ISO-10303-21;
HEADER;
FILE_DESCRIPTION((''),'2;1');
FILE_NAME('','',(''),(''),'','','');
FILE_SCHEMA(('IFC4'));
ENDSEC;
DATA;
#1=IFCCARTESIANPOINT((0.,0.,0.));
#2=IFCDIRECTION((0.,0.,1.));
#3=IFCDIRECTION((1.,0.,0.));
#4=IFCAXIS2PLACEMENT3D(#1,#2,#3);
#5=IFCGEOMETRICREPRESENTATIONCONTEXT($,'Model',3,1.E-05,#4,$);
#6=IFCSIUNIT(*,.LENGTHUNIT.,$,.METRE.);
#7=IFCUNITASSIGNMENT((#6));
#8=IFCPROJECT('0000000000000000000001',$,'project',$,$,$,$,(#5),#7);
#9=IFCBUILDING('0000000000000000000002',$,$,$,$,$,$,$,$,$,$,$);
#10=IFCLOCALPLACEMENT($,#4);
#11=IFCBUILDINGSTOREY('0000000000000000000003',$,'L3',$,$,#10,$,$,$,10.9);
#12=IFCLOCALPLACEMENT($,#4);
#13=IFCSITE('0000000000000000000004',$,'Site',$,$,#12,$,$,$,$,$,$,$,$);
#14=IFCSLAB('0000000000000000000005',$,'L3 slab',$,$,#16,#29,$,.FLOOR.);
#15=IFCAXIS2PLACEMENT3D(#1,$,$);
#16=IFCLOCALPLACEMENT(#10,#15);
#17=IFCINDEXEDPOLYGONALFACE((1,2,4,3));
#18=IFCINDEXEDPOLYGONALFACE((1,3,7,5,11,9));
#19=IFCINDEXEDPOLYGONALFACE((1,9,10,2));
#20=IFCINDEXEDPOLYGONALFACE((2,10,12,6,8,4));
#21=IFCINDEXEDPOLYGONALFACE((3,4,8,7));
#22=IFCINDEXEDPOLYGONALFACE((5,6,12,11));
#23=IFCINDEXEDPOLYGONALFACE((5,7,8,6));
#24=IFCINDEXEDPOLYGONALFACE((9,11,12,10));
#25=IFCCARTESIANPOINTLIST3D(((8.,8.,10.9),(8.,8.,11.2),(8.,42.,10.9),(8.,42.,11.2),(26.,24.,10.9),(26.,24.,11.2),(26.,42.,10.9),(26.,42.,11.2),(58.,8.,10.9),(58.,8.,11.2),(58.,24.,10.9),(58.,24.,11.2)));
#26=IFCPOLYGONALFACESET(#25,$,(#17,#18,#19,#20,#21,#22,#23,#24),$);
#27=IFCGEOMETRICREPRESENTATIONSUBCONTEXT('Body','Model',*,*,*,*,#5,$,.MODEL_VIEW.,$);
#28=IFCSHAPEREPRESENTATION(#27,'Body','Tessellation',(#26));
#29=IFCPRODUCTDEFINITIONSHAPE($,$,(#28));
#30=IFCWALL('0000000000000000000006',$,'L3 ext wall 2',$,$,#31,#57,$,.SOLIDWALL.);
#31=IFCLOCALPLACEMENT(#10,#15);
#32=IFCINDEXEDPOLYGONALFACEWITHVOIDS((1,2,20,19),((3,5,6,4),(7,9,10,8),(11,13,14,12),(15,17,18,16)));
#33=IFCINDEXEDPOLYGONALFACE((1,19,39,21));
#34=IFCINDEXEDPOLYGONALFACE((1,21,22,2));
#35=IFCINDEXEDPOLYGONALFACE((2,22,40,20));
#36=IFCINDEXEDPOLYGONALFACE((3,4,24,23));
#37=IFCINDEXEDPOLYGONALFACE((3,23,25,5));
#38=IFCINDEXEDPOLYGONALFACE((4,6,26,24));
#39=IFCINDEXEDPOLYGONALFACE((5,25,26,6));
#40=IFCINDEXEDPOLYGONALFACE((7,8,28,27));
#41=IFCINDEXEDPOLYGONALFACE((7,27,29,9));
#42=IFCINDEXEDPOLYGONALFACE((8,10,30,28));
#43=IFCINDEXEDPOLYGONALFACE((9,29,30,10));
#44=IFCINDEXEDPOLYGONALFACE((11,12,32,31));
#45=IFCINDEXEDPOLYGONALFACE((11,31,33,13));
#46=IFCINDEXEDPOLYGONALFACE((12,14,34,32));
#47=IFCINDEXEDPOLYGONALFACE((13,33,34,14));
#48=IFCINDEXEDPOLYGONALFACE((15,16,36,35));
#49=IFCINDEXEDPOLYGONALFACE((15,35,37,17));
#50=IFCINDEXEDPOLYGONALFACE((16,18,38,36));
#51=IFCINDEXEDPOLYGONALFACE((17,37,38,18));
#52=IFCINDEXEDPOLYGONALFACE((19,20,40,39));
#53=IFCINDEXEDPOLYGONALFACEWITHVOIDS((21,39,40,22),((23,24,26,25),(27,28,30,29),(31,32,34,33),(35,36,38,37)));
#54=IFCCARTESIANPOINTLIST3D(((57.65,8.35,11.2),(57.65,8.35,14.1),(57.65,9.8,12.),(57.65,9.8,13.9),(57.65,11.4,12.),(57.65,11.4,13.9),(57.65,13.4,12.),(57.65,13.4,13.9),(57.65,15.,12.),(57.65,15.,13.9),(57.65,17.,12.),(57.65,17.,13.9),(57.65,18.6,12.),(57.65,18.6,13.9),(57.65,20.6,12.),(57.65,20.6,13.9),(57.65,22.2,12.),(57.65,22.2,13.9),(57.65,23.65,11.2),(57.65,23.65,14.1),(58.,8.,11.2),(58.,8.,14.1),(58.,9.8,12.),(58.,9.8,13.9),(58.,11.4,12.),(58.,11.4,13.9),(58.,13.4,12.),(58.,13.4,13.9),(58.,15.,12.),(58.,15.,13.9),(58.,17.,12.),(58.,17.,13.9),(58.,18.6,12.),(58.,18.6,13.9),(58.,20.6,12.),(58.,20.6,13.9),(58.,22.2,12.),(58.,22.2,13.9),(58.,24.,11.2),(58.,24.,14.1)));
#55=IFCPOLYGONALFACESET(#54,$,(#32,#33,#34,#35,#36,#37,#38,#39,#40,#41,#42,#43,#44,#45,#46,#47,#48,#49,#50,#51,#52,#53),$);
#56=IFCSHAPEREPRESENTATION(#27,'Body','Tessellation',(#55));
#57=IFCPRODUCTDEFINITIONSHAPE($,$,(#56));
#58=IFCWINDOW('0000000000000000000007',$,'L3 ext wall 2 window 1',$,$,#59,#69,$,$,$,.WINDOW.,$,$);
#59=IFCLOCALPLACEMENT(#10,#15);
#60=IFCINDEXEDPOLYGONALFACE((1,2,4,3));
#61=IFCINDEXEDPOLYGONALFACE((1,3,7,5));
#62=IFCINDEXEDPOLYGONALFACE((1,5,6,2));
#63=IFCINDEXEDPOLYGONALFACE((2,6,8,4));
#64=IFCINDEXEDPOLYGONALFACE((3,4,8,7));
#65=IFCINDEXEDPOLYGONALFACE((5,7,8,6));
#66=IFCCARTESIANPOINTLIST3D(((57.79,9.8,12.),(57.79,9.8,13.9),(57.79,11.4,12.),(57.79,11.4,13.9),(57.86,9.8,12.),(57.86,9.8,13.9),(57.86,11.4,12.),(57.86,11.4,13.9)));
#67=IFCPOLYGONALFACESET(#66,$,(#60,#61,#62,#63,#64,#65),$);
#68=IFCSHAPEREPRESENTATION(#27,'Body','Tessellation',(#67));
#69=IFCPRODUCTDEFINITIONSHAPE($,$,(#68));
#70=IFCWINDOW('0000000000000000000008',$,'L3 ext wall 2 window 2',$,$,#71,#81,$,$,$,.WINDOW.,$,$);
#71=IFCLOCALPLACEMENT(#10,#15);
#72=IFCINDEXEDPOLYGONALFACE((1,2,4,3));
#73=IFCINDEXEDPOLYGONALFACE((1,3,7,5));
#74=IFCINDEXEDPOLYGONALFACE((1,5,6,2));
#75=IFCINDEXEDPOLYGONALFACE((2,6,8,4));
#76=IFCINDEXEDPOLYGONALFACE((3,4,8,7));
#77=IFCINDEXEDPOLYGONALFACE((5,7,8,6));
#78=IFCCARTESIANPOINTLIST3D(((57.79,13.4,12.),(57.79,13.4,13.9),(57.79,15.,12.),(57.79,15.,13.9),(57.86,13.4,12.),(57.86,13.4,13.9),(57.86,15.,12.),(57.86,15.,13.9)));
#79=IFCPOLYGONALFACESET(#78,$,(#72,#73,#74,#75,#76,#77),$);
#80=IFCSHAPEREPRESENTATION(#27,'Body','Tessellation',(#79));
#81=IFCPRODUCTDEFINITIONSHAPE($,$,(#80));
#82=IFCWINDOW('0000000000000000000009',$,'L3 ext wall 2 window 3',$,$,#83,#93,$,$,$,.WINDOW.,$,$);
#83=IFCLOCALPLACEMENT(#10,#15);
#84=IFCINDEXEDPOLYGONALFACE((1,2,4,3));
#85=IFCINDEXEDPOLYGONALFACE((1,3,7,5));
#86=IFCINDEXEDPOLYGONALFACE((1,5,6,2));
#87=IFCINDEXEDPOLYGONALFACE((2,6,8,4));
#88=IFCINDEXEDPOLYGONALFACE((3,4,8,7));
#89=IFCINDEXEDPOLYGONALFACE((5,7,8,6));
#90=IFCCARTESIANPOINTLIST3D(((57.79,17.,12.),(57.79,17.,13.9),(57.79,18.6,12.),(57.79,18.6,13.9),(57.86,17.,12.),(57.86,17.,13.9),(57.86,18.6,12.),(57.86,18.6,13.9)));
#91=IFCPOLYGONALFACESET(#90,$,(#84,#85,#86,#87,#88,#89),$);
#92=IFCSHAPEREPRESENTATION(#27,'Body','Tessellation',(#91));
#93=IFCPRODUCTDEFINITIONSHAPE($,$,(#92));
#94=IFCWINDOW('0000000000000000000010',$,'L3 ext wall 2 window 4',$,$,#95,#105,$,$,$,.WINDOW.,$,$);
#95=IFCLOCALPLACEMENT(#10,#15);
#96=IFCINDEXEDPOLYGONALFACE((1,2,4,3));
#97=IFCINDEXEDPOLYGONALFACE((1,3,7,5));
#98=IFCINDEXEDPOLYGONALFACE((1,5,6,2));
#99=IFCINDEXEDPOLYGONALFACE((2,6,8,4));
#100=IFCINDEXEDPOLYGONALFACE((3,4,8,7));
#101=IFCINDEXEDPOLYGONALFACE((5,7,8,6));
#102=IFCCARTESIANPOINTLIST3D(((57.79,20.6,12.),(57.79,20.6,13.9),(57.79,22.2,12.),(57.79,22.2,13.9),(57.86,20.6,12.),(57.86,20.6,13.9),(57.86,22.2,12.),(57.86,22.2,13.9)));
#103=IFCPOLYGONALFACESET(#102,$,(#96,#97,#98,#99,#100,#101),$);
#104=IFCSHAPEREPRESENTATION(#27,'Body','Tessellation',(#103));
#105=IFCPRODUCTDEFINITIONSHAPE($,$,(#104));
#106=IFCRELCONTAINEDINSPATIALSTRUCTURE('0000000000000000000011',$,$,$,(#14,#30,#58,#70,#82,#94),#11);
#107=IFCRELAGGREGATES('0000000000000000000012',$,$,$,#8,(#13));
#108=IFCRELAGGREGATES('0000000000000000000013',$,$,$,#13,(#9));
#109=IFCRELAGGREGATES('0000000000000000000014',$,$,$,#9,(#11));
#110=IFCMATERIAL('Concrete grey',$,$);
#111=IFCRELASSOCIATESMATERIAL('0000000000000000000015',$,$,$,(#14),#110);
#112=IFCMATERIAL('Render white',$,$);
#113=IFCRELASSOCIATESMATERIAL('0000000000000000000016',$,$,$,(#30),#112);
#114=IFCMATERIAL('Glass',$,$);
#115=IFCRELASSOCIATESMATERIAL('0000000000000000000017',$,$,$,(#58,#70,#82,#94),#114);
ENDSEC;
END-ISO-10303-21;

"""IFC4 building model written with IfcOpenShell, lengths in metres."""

from ifc_helpers import new_model, si_unit, frame, origin_with_axes, place, context, subcontext, project, spatial, polyline, outline, extrude, material, element, fill, save


model = new_model("IFC4")

# Units and contexts
model_context = context("Model", 3, precision=1e-05, world=origin_with_axes())
body_context = subcontext(model_context, "Body", "Model", "MODEL_VIEW")
ifc_project = project(units=[si_unit("LENGTHUNIT", "METRE")], contexts=[model_context])

# Site, building, storey
site_placement = place(None, origin_with_axes())
site = spatial("IfcSite", under=ifc_project, at=site_placement, Name="Site")
building = spatial("IfcBuilding", under=site)
storey_placement = place(None, origin_with_axes())
storey = spatial("IfcBuildingStorey", under=building, at=storey_placement, Name="L3", Elevation=10.9)

# Slab
ifc_material_1 = material(Name="Concrete grey")
slab_placement = place(storey_placement, origin_with_axes())
element("IfcSlab", 1, at=slab_placement, inside=storey, material=ifc_material_1, Name="L3 slab", PredefinedType="FLOOR", context=body_context, shape_type="SweptSolid", body=[
    extrude(outline(polyline([(8.0, 8.0), (58.0, 8.0), (58.0, 24.0), (26.0, 24.0), (26.0, 42.0), (8.0, 42.0), (8.0, 8.0)])), frame((0.0, 0.0, 10.9), z_axis=(0.0, 0.0, 1.0), x_axis=(1.0, 0.0, 0.0)), (0.0, 0.0, 1.0), 0.3),
])

# Wall, openings, windows
ifc_material_2 = material(Name="Render white")
ifc_material_3 = material(Name="Glass")
wall_1_placement = place(storey_placement, origin_with_axes())
wall_1 = element("IfcWall", 2, at=wall_1_placement, inside=storey, material=ifc_material_2, Name="L3 ext wall 2", PredefinedType="SOLIDWALL", context=body_context, shape_type="SweptSolid", body=[
    extrude(outline(polyline([(58.0, 8.0), (58.0, 24.0), (57.65, 23.65), (57.65, 8.35), (58.0, 8.0)])), frame((0.0, 0.0, 11.2), z_axis=(0.0, 0.0, 1.0), x_axis=(1.0, 0.0, 0.0)), (0.0, 0.0, 1.0), 2.9),
])
opening_1_placement = place(wall_1_placement, origin_with_axes())
opening_1 = element("IfcOpeningElement", 3, at=opening_1_placement, cuts=wall_1, context=body_context, shape_type="SweptSolid", body=[
    extrude(outline(polyline([(58.05, 9.8), (58.05, 11.4), (57.6, 11.4), (57.6, 9.8), (58.05, 9.8)])), frame((0.0, 0.0, 12.0), z_axis=(0.0, 0.0, 1.0), x_axis=(1.0, 0.0, 0.0)), (0.0, 0.0, 1.0), 1.9),
])
opening_2_placement = place(wall_1_placement, origin_with_axes())
opening_2 = element("IfcOpeningElement", 4, at=opening_2_placement, cuts=wall_1, context=body_context, shape_type="SweptSolid", body=[
    extrude(outline(polyline([(58.05, 13.4), (58.05, 15.0), (57.6, 15.0), (57.6, 13.4), (58.05, 13.4)])), frame((0.0, 0.0, 12.0), z_axis=(0.0, 0.0, 1.0), x_axis=(1.0, 0.0, 0.0)), (0.0, 0.0, 1.0), 1.9),
])
opening_3_placement = place(wall_1_placement, origin_with_axes())
opening_3 = element("IfcOpeningElement", 5, at=opening_3_placement, cuts=wall_1, context=body_context, shape_type="SweptSolid", body=[
    extrude(outline(polyline([(58.05, 17.0), (58.05, 18.6), (57.6, 18.6), (57.6, 17.0), (58.05, 17.0)])), frame((0.0, 0.0, 12.0), z_axis=(0.0, 0.0, 1.0), x_axis=(1.0, 0.0, 0.0)), (0.0, 0.0, 1.0), 1.9),
])
opening_4_placement = place(wall_1_placement, origin_with_axes())
opening_4 = element("IfcOpeningElement", 6, at=opening_4_placement, cuts=wall_1, context=body_context, shape_type="SweptSolid", body=[
    extrude(outline(polyline([(58.05, 20.6), (58.05, 22.2), (57.6, 22.2), (57.6, 20.6), (58.05, 20.6)])), frame((0.0, 0.0, 12.0), z_axis=(0.0, 0.0, 1.0), x_axis=(1.0, 0.0, 0.0)), (0.0, 0.0, 1.0), 1.9),
])
window_1_placement = place(storey_placement, origin_with_axes())
window_1 = element("IfcWindow", 7, at=window_1_placement, inside=storey, material=ifc_material_3, Name="L3 ext wall 2 window 1", PredefinedType="WINDOW", context=body_context, shape_type="SweptSolid", body=[
    extrude(outline(polyline([(57.86, 9.8), (57.86, 11.4), (57.79, 11.4), (57.79, 9.8), (57.86, 9.8)])), frame((0.0, 0.0, 12.0), z_axis=(0.0, 0.0, 1.0), x_axis=(1.0, 0.0, 0.0)), (0.0, 0.0, 1.0), 1.9),
])
fill(opening_1, window_1)
window_2_placement = place(storey_placement, origin_with_axes())
window_2 = element("IfcWindow", 8, at=window_2_placement, inside=storey, material=ifc_material_3, Name="L3 ext wall 2 window 2", PredefinedType="WINDOW", context=body_context, shape_type="SweptSolid", body=[
    extrude(outline(polyline([(57.86, 13.4), (57.86, 15.0), (57.79, 15.0), (57.79, 13.4), (57.86, 13.4)])), frame((0.0, 0.0, 12.0), z_axis=(0.0, 0.0, 1.0), x_axis=(1.0, 0.0, 0.0)), (0.0, 0.0, 1.0), 1.9),
])
fill(opening_2, window_2)
window_3_placement = place(storey_placement, origin_with_axes())
window_3 = element("IfcWindow", 9, at=window_3_placement, inside=storey, material=ifc_material_3, Name="L3 ext wall 2 window 3", PredefinedType="WINDOW", context=body_context, shape_type="SweptSolid", body=[
    extrude(outline(polyline([(57.86, 17.0), (57.86, 18.6), (57.79, 18.6), (57.79, 17.0), (57.86, 17.0)])), frame((0.0, 0.0, 12.0), z_axis=(0.0, 0.0, 1.0), x_axis=(1.0, 0.0, 0.0)), (0.0, 0.0, 1.0), 1.9),
])
fill(opening_3, window_3)
window_4_placement = place(storey_placement, origin_with_axes())
window_4 = element("IfcWindow", 10, at=window_4_placement, inside=storey, material=ifc_material_3, Name="L3 ext wall 2 window 4", PredefinedType="WINDOW", context=body_context, shape_type="SweptSolid", body=[
    extrude(outline(polyline([(57.86, 20.6), (57.86, 22.2), (57.79, 22.2), (57.79, 20.6), (57.86, 20.6)])), frame((0.0, 0.0, 12.0), z_axis=(0.0, 0.0, 1.0), x_axis=(1.0, 0.0, 0.0)), (0.0, 0.0, 1.0), 1.9),
])
fill(opening_4, window_4)

save(model, "model.ifc")
